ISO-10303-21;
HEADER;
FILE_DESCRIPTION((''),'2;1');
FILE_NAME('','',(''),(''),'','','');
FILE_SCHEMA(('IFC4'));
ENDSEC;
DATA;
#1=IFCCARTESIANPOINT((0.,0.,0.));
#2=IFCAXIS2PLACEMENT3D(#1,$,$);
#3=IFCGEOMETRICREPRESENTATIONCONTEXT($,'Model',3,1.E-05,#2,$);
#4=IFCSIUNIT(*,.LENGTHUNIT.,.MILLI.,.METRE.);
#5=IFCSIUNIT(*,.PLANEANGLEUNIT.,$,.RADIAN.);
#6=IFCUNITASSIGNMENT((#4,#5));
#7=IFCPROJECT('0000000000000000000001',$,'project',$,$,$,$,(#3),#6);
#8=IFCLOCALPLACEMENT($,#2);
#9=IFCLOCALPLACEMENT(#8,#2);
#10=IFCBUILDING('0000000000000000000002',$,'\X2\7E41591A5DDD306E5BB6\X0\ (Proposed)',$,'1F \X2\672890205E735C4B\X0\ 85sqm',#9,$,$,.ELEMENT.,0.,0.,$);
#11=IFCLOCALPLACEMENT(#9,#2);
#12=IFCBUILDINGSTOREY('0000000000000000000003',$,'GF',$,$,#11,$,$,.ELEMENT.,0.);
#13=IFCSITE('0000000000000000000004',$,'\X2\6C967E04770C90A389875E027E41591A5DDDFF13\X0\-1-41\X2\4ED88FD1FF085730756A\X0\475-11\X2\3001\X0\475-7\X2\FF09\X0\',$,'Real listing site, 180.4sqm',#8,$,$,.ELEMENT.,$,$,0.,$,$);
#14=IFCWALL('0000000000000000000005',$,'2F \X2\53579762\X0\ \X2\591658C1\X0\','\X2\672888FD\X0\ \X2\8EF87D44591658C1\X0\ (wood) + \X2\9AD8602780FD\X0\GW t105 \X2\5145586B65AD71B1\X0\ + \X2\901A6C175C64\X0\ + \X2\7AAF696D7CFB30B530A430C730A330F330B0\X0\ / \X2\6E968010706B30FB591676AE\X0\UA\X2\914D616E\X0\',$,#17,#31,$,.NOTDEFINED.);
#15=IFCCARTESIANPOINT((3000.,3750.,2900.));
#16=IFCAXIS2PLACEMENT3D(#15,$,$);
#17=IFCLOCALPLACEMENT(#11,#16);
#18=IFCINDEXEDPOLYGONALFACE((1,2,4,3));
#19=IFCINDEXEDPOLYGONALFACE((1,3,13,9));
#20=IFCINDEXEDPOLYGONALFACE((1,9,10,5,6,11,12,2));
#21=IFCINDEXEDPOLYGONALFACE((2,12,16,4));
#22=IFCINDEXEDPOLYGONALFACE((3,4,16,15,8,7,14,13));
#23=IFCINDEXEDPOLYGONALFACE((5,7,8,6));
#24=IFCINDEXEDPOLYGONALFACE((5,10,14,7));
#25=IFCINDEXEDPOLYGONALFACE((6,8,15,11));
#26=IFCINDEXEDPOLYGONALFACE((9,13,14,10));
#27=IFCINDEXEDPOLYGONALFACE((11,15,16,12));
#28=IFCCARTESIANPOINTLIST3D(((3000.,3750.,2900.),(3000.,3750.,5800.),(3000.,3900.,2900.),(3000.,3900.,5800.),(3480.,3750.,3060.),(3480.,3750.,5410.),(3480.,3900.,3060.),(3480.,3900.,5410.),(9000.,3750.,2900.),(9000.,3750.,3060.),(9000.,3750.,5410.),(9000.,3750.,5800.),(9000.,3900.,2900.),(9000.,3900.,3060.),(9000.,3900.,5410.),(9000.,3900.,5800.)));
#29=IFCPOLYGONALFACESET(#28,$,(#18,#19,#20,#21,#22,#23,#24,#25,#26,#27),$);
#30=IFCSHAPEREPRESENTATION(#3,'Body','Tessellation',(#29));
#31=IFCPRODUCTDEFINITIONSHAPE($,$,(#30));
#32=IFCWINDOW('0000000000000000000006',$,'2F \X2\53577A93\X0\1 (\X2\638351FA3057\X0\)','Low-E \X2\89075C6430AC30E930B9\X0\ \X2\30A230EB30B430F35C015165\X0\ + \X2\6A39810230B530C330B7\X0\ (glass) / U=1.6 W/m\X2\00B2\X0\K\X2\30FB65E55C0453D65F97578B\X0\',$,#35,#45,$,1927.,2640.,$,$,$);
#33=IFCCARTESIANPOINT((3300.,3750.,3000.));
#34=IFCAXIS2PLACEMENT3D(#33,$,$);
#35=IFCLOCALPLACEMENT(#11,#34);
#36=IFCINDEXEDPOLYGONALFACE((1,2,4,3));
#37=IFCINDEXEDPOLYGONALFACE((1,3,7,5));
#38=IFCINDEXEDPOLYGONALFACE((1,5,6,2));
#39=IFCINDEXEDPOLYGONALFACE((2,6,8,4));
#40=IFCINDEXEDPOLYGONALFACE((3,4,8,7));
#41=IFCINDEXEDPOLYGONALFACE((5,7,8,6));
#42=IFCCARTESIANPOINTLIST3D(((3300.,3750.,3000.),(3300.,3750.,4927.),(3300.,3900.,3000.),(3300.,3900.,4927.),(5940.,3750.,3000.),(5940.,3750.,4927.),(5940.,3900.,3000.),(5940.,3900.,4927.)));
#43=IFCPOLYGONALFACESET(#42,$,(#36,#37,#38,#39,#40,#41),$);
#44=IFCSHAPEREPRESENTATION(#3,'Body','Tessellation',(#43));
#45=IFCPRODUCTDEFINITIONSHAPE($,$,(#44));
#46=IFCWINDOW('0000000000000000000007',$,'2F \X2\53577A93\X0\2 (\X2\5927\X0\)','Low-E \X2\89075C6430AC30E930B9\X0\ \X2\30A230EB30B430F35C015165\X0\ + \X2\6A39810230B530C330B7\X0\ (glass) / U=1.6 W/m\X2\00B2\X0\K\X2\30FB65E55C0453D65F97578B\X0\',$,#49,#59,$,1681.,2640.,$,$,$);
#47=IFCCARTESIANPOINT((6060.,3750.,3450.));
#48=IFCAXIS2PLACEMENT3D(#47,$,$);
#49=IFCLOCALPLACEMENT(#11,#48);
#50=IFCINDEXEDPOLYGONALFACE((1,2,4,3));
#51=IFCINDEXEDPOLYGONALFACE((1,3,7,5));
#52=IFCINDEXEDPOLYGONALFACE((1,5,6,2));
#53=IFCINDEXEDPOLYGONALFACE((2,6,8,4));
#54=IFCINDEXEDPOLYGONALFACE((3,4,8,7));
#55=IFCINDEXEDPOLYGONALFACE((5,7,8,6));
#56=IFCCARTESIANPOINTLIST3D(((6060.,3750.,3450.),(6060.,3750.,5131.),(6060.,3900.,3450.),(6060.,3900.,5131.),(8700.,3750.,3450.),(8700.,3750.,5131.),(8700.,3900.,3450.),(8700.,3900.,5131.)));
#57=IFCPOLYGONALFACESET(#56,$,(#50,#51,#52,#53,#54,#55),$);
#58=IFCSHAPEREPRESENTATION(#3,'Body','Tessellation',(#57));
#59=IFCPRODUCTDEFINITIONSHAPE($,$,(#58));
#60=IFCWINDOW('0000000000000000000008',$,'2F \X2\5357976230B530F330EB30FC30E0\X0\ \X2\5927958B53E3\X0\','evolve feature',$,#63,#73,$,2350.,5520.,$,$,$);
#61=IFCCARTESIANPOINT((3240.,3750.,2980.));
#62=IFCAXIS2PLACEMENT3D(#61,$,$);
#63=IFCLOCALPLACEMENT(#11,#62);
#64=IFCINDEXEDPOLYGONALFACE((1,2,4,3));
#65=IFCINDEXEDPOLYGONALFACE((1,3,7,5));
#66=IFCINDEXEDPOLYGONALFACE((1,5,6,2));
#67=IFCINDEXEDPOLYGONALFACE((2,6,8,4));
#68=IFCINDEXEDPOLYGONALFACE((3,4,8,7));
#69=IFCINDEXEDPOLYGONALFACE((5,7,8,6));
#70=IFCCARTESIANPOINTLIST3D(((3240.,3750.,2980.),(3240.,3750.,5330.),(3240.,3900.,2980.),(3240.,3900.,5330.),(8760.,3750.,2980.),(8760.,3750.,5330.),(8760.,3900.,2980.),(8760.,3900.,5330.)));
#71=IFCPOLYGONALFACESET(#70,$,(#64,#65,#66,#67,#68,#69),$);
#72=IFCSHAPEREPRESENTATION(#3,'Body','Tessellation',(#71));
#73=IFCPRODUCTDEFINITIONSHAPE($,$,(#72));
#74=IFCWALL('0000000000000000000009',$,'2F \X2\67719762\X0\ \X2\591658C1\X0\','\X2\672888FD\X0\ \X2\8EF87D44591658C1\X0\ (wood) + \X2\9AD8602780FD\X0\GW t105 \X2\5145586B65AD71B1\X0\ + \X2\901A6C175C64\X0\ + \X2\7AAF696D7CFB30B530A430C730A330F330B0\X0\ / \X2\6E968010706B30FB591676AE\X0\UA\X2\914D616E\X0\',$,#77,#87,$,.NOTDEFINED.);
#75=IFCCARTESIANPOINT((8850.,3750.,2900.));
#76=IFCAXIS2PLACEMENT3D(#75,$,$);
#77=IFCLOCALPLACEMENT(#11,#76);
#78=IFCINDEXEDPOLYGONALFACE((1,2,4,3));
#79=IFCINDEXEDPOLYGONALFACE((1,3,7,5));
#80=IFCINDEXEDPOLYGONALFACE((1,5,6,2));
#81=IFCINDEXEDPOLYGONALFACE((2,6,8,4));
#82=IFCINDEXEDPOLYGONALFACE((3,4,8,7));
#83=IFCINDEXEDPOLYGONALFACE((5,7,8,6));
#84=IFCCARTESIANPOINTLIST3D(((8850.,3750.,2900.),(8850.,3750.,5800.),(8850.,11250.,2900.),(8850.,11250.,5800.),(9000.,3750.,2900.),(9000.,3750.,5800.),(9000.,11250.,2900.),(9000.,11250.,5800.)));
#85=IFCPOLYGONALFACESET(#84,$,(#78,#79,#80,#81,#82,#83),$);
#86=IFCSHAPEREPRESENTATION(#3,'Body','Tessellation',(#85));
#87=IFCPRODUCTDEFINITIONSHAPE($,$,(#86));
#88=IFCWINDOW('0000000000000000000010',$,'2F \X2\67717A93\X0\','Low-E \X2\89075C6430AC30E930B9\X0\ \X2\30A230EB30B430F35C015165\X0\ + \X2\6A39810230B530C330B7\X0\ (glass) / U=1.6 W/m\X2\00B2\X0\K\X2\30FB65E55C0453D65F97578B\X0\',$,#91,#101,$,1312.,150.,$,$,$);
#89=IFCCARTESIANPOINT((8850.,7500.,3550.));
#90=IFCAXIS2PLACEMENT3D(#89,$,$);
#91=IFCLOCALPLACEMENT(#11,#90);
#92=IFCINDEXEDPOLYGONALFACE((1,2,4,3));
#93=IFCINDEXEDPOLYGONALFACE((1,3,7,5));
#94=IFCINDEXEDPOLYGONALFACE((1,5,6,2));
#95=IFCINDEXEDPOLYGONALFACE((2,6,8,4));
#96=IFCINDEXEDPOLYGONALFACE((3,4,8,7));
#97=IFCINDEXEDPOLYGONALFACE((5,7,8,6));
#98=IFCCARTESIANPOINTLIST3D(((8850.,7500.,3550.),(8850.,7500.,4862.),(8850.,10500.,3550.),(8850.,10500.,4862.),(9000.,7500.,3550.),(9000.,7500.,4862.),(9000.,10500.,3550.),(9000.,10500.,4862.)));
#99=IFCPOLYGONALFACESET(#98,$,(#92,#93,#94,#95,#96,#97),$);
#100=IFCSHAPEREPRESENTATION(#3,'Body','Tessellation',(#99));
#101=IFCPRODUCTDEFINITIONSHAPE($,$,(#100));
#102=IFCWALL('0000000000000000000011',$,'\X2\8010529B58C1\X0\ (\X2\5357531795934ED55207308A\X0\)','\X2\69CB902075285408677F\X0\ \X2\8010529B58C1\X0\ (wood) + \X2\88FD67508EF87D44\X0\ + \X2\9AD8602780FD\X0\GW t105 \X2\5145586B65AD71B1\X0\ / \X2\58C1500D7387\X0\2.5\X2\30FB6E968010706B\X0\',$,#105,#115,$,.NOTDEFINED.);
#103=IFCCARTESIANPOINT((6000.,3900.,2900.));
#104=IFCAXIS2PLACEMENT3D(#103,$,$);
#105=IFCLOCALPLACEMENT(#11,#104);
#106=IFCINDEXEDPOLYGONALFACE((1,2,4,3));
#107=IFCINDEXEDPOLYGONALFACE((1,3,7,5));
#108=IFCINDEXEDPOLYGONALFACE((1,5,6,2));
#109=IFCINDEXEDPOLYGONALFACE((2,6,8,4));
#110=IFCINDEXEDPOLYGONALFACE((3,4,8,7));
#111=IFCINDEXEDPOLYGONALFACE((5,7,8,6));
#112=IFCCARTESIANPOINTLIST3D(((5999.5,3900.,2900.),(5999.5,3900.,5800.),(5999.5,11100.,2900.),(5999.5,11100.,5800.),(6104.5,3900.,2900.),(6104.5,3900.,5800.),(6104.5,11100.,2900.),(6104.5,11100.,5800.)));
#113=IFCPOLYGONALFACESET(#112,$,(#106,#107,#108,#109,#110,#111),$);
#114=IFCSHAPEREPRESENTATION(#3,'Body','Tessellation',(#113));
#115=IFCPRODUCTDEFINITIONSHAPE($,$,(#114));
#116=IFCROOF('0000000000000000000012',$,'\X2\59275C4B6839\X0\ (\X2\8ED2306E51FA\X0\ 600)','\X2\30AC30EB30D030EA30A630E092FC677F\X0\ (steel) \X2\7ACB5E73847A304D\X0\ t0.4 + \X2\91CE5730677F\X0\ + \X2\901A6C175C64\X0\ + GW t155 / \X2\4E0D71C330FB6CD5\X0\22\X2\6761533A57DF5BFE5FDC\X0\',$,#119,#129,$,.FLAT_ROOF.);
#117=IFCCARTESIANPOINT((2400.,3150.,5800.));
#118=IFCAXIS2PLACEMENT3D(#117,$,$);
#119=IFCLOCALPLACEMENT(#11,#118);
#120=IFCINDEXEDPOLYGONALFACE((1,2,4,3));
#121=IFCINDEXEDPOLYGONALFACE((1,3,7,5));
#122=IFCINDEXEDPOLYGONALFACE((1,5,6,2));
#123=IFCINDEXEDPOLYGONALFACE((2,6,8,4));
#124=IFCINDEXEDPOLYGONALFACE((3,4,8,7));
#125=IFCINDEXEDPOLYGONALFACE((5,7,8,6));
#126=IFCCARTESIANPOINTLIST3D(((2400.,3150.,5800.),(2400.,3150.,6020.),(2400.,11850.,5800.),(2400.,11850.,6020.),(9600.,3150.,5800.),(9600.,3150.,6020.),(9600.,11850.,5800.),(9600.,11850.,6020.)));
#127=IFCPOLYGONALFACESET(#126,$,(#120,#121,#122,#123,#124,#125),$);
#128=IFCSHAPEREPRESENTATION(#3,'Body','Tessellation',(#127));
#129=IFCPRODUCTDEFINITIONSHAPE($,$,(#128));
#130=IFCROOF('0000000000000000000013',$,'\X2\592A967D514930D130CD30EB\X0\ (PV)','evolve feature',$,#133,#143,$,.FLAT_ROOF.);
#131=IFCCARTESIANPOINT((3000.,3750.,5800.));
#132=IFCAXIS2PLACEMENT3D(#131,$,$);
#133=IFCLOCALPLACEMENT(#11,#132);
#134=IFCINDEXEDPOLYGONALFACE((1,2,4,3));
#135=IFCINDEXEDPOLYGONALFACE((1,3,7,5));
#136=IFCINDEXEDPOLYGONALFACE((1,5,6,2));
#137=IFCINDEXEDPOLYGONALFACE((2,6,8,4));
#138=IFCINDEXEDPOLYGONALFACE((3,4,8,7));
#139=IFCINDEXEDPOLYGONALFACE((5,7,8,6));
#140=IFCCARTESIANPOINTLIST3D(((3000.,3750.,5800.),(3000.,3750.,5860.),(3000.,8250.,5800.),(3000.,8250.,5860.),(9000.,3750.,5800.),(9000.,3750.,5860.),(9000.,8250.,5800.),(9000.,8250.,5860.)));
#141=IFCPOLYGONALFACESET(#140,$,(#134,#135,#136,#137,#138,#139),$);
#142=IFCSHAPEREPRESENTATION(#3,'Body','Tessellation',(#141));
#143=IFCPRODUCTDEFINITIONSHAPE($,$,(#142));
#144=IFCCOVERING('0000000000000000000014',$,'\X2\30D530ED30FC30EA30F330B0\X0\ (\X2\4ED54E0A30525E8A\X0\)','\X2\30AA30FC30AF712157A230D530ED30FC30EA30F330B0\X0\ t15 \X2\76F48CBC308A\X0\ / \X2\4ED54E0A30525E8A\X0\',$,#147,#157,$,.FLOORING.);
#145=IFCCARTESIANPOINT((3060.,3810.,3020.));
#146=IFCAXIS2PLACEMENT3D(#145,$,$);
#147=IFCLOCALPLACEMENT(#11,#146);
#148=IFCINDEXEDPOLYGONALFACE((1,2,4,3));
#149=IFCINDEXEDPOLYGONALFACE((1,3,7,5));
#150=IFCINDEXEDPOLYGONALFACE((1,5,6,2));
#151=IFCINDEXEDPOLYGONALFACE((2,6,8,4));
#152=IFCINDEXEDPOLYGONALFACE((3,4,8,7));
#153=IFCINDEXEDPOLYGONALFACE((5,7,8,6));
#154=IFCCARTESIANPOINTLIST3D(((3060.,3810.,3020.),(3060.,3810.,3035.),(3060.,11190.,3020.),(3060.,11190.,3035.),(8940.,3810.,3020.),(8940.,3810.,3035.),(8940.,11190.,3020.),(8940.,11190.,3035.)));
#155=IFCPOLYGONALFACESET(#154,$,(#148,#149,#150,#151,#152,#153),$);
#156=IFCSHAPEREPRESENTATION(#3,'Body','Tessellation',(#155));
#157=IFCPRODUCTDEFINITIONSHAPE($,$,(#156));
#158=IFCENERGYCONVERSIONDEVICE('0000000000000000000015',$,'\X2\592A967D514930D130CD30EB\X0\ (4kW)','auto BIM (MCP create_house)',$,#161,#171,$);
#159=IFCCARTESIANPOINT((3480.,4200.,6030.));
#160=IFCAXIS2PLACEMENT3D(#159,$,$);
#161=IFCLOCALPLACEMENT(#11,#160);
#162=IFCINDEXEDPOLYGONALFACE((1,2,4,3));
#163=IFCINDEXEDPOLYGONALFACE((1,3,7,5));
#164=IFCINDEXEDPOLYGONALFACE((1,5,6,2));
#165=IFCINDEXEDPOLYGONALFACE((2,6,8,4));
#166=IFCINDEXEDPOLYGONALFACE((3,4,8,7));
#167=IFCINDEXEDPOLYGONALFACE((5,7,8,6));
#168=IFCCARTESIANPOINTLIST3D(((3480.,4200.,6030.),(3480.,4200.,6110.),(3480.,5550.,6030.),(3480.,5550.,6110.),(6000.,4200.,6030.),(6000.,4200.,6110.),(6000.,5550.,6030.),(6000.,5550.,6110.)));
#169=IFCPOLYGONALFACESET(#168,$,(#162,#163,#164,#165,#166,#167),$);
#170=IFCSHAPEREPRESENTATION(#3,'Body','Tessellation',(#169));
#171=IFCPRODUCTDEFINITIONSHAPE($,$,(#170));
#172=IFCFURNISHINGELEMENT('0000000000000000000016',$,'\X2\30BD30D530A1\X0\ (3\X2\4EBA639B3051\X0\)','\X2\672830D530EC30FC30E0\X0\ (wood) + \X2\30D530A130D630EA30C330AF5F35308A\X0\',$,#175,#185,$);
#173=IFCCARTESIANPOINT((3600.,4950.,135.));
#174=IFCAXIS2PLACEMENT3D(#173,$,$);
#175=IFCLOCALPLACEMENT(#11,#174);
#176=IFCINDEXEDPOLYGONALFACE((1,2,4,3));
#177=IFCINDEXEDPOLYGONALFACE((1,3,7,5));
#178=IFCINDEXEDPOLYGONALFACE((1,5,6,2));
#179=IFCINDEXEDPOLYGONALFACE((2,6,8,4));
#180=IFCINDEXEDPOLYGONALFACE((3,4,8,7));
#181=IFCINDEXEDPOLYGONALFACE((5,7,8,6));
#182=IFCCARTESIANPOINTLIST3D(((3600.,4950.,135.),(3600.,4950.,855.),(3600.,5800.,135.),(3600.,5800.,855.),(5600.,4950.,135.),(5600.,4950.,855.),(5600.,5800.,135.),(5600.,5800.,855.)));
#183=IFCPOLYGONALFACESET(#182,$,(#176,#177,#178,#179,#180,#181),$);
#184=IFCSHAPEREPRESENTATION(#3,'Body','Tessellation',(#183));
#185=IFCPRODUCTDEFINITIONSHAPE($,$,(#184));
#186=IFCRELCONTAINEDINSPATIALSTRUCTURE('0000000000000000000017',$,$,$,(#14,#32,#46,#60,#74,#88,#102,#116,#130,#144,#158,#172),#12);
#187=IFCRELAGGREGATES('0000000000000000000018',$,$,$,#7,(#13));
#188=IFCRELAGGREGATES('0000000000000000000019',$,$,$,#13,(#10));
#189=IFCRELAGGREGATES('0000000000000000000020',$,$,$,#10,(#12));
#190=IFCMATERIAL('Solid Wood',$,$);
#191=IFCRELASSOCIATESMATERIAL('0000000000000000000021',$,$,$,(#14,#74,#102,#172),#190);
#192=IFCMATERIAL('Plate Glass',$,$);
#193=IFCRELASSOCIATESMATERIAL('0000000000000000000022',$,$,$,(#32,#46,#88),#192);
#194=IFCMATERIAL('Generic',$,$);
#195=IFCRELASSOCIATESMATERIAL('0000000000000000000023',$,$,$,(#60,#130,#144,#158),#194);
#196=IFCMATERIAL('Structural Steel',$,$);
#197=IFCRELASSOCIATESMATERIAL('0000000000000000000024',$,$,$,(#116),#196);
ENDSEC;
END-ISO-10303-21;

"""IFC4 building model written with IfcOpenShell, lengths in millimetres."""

from ifc_helpers import new_model, si_unit, frame, frame_2d, origin, place, context, project, spatial, rectangle, extrude, material, element, fill, save


model = new_model("IFC4")

# Units and contexts
model_context = context("Model", 3, precision=1e-05, world=origin())
ifc_project = project(units=[si_unit("LENGTHUNIT", "METRE", prefix="MILLI"), si_unit("PLANEANGLEUNIT", "RADIAN")], contexts=[model_context])

# Site, building, storey
site_placement = place(None, origin())
site = spatial("IfcSite", under=ifc_project, at=site_placement, Name="沖縄県那覇市繁多川３-1-41付近（地番475-11、475-7）", ObjectType="Real listing site, 180.4sqm", CompositionType="ELEMENT", RefElevation=0.0)
building_placement = place(site_placement, origin())
building = spatial("IfcBuilding", under=site, at=building_placement, Name="繁多川の家 (Proposed)", ObjectType="1F 木造平屋 85sqm", CompositionType="ELEMENT", ElevationOfRefHeight=0.0, ElevationOfTerrain=0.0)
storey_placement = place(building_placement, origin())
storey = spatial("IfcBuildingStorey", under=building, at=storey_placement, Name="GF", CompositionType="ELEMENT", Elevation=0.0)

# Shared definitions
ifc_material_1 = material(Name="Solid Wood")

# Wall, openings, windows
wall_1_placement = place(storey_placement, frame((3000.0, 3750.0, 2900.0)))
wall_1 = element("IfcWall", 1, at=wall_1_placement, inside=storey, material=ifc_material_1, Name="2F 南面 外壁", Description="木製 軸組外壁 (wood) + 高性能GW t105 充填断熱 + 通気層 + 窯業系サイディング / 準耐火・外皮UA配慮", PredefinedType="NOTDEFINED", context=model_context, shape_type="SweptSolid", body=[
    extrude(rectangle(XDim=6000.0, YDim=150.0, at=frame_2d((3000.0, 75.0))), frame((3000.0, 3750.0, 2900.0)), (0.0, 0.0, 1.0), 2900.0),
])
opening_1_placement = place(storey_placement, frame((3300.0, 3750.0, 3000.0)))
opening_1 = element("IfcOpeningElement", 2, at=opening_1_placement, cuts=wall_1, PredefinedType="NOTDEFINED", context=model_context, shape_type="SweptSolid", body=[
    extrude(rectangle(XDim=2640.0, YDim=150.0, at=frame_2d((1320.0, 75.0))), frame((3300.0, 3750.0, 3000.0)), (0.0, 0.0, 1.0), 1927.0),
])
opening_2_placement = place(storey_placement, frame((6060.0, 3750.0, 3450.0)))
opening_2 = element("IfcOpeningElement", 3, at=opening_2_placement, cuts=wall_1, PredefinedType="NOTDEFINED", context=model_context, shape_type="SweptSolid", body=[
    extrude(rectangle(XDim=2640.0, YDim=150.0, at=frame_2d((1320.0, 75.0))), frame((6060.0, 3750.0, 3450.0)), (0.0, 0.0, 1.0), 1681.0),
])
opening_3_placement = place(storey_placement, frame((3240.0, 3750.0, 2980.0)))
opening_3 = element("IfcOpeningElement", 4, at=opening_3_placement, cuts=wall_1, PredefinedType="NOTDEFINED", context=model_context, shape_type="SweptSolid", body=[
    extrude(rectangle(XDim=5520.0, YDim=150.0, at=frame_2d((2760.0, 75.0))), frame((3240.0, 3750.0, 2980.0)), (0.0, 0.0, 1.0), 2350.0),
])
ifc_material_2 = material(Name="Plate Glass")
window_1_placement = place(storey_placement, frame((3300.0, 3750.0, 3000.0)))
window_1 = element("IfcWindow", 5, at=window_1_placement, inside=storey, material=ifc_material_2, Name="2F 南窓1 (掃出し)", Description="Low-E 複層ガラス アルゴン封入 + 樹脂サッシ (glass) / U=1.6 W/m²K・日射取得型", OverallHeight=1927.0, OverallWidth=2640.0, context=model_context, shape_type="SweptSolid", body=[
    extrude(rectangle(XDim=2640.0, YDim=150.0, at=frame_2d((1320.0, 75.0))), frame((3300.0, 3750.0, 3000.0)), (0.0, 0.0, 1.0), 1927.0),
])
fill(opening_1, window_1)
window_2_placement = place(storey_placement, frame((6060.0, 3750.0, 3450.0)))
window_2 = element("IfcWindow", 6, at=window_2_placement, inside=storey, material=ifc_material_2, Name="2F 南窓2 (大)", Description="Low-E 複層ガラス アルゴン封入 + 樹脂サッシ (glass) / U=1.6 W/m²K・日射取得型", OverallHeight=1681.0, OverallWidth=2640.0, context=model_context, shape_type="SweptSolid", body=[
    extrude(rectangle(XDim=2640.0, YDim=150.0, at=frame_2d((1320.0, 75.0))), frame((6060.0, 3750.0, 3450.0)), (0.0, 0.0, 1.0), 1681.0),
])
fill(opening_2, window_2)
ifc_material_3 = material(Name="Generic")
window_3_placement = place(storey_placement, frame((3240.0, 3750.0, 2980.0)))
window_3 = element("IfcWindow", 7, at=window_3_placement, inside=storey, material=ifc_material_3, Name="2F 南面サンルーム 大開口", Description="evolve feature", OverallHeight=2350.0, OverallWidth=5520.0, context=model_context, shape_type="SweptSolid", body=[
    extrude(rectangle(XDim=5520.0, YDim=150.0, at=frame_2d((2760.0, 75.0))), frame((3240.0, 3750.0, 2980.0)), (0.0, 0.0, 1.0), 2350.0),
])
fill(opening_3, window_3)

# Wall, opening, window
wall_2_placement = place(storey_placement, frame((8850.0, 3750.0, 2900.0)))
wall_2 = element("IfcWall", 8, at=wall_2_placement, inside=storey, material=ifc_material_1, Name="2F 東面 外壁", Description="木製 軸組外壁 (wood) + 高性能GW t105 充填断熱 + 通気層 + 窯業系サイディング / 準耐火・外皮UA配慮", PredefinedType="NOTDEFINED", context=model_context, shape_type="SweptSolid", body=[
    extrude(rectangle(XDim=150.0, YDim=7500.0, at=frame_2d((75.0, 3750.0))), frame((8850.0, 3750.0, 2900.0)), (0.0, 0.0, 1.0), 2900.0),
])
opening_4_placement = place(storey_placement, frame((8850.0, 7500.0, 3550.0)))
opening_4 = element("IfcOpeningElement", 9, at=opening_4_placement, cuts=wall_2, PredefinedType="NOTDEFINED", context=model_context, shape_type="SweptSolid", body=[
    extrude(rectangle(XDim=150.0, YDim=3000.0, at=frame_2d((75.0, 1500.0))), frame((8850.0, 7500.0, 3550.0)), (0.0, 0.0, 1.0), 1312.0),
])
window_4_placement = place(storey_placement, frame((8850.0, 7500.0, 3550.0)))
window_4 = element("IfcWindow", 10, at=window_4_placement, inside=storey, material=ifc_material_2, Name="2F 東窓", Description="Low-E 複層ガラス アルゴン封入 + 樹脂サッシ (glass) / U=1.6 W/m²K・日射取得型", OverallHeight=1312.0, OverallWidth=150.0, context=model_context, shape_type="SweptSolid", body=[
    extrude(rectangle(XDim=150.0, YDim=3000.0, at=frame_2d((75.0, 1500.0))), frame((8850.0, 7500.0, 3550.0)), (0.0, 0.0, 1.0), 1312.0),
])
fill(opening_4, window_4)

# Wall
wall_3_placement = place(storey_placement, frame((6000.0, 3900.0, 2900.0)))
element("IfcWall", 11, at=wall_3_placement, inside=storey, material=ifc_material_1, Name="耐力壁 (南北間仕切り)", Description="構造用合板 耐力壁 (wood) + 製材軸組 + 高性能GW t105 充填断熱 / 壁倍率2.5・準耐火", PredefinedType="NOTDEFINED", context=model_context, shape_type="SweptSolid", body=[
    extrude(rectangle(XDim=105.0, YDim=7200.0, at=frame_2d((52.0, 3600.0))), frame((6000.0, 3900.0, 2900.0)), (0.0, 0.0, 1.0), 2900.0),
])

# Roofs
ifc_material_4 = material(Name="Structural Steel")
roof_1_placement = place(storey_placement, frame((2400.0, 3150.0, 5800.0)))
element("IfcRoof", 12, at=roof_1_placement, inside=storey, material=ifc_material_4, Name="大屋根 (軒の出 600)", Description="ガルバリウム鋼板 (steel) 立平葺き t0.4 + 野地板 + 通気層 + GW t155 / 不燃・法22条区域対応", PredefinedType="FLAT_ROOF", context=model_context, shape_type="SweptSolid", body=[
    extrude(rectangle(XDim=7200.0, YDim=8700.0, at=frame_2d((3600.0, 4350.0))), frame((2400.0, 3150.0, 5800.0)), (0.0, 0.0, 1.0), 220.0),
])
roof_2_placement = place(storey_placement, frame((3000.0, 3750.0, 5800.0)))
element("IfcRoof", 13, at=roof_2_placement, inside=storey, material=ifc_material_3, Name="太陽光パネル (PV)", Description="evolve feature", PredefinedType="FLAT_ROOF", context=model_context, shape_type="SweptSolid", body=[
    extrude(rectangle(XDim=6000.0, YDim=4500.0, at=frame_2d((3000.0, 2250.0))), frame((3000.0, 3750.0, 5800.0)), (0.0, 0.0, 1.0), 60.0),
])

# Covering
covering_placement = place(storey_placement, frame((3060.0, 3810.0, 3020.0)))
element("IfcCovering", 14, at=covering_placement, inside=storey, material=ifc_material_3, Name="フローリング (仕上げ床)", Description="オーク無垢フローリング t15 直貼り / 仕上げ床", PredefinedType="FLOORING", context=model_context, shape_type="SweptSolid", body=[
    extrude(rectangle(XDim=5880.0, YDim=7380.0, at=frame_2d((2940.0, 3690.0))), frame((3060.0, 3810.0, 3020.0)), (0.0, 0.0, 1.0), 15.0),
])

# Energy conversion device
energy_conversion_device_placement = place(storey_placement, frame((3480.0, 4200.0, 6030.0)))
element("IfcEnergyConversionDevice", 15, at=energy_conversion_device_placement, inside=storey, material=ifc_material_3, Name="太陽光パネル (4kW)", Description="auto BIM (MCP create_house)", context=model_context, shape_type="SweptSolid", body=[
    extrude(rectangle(XDim=2520.0, YDim=1350.0, at=frame_2d((1260.0, 675.0))), frame((3480.0, 4200.0, 6030.0)), (0.0, 0.0, 1.0), 80.0),
])

# Furnishing element
furnishing_1_placement = place(storey_placement, frame((3600.0, 4950.0, 135.0)))
element("IfcFurnishingElement", 16, at=furnishing_1_placement, inside=storey, material=ifc_material_1, Name="ソファ (3人掛け)", Description="木フレーム (wood) + ファブリック張り", context=model_context, shape_type="SweptSolid", body=[
    extrude(rectangle(XDim=2000.0, YDim=850.0, at=frame_2d((1000.0, 425.0))), frame((3600.0, 4950.0, 135.0)), (0.0, 0.0, 1.0), 720.0),
])

save(model, "model.ifc")
